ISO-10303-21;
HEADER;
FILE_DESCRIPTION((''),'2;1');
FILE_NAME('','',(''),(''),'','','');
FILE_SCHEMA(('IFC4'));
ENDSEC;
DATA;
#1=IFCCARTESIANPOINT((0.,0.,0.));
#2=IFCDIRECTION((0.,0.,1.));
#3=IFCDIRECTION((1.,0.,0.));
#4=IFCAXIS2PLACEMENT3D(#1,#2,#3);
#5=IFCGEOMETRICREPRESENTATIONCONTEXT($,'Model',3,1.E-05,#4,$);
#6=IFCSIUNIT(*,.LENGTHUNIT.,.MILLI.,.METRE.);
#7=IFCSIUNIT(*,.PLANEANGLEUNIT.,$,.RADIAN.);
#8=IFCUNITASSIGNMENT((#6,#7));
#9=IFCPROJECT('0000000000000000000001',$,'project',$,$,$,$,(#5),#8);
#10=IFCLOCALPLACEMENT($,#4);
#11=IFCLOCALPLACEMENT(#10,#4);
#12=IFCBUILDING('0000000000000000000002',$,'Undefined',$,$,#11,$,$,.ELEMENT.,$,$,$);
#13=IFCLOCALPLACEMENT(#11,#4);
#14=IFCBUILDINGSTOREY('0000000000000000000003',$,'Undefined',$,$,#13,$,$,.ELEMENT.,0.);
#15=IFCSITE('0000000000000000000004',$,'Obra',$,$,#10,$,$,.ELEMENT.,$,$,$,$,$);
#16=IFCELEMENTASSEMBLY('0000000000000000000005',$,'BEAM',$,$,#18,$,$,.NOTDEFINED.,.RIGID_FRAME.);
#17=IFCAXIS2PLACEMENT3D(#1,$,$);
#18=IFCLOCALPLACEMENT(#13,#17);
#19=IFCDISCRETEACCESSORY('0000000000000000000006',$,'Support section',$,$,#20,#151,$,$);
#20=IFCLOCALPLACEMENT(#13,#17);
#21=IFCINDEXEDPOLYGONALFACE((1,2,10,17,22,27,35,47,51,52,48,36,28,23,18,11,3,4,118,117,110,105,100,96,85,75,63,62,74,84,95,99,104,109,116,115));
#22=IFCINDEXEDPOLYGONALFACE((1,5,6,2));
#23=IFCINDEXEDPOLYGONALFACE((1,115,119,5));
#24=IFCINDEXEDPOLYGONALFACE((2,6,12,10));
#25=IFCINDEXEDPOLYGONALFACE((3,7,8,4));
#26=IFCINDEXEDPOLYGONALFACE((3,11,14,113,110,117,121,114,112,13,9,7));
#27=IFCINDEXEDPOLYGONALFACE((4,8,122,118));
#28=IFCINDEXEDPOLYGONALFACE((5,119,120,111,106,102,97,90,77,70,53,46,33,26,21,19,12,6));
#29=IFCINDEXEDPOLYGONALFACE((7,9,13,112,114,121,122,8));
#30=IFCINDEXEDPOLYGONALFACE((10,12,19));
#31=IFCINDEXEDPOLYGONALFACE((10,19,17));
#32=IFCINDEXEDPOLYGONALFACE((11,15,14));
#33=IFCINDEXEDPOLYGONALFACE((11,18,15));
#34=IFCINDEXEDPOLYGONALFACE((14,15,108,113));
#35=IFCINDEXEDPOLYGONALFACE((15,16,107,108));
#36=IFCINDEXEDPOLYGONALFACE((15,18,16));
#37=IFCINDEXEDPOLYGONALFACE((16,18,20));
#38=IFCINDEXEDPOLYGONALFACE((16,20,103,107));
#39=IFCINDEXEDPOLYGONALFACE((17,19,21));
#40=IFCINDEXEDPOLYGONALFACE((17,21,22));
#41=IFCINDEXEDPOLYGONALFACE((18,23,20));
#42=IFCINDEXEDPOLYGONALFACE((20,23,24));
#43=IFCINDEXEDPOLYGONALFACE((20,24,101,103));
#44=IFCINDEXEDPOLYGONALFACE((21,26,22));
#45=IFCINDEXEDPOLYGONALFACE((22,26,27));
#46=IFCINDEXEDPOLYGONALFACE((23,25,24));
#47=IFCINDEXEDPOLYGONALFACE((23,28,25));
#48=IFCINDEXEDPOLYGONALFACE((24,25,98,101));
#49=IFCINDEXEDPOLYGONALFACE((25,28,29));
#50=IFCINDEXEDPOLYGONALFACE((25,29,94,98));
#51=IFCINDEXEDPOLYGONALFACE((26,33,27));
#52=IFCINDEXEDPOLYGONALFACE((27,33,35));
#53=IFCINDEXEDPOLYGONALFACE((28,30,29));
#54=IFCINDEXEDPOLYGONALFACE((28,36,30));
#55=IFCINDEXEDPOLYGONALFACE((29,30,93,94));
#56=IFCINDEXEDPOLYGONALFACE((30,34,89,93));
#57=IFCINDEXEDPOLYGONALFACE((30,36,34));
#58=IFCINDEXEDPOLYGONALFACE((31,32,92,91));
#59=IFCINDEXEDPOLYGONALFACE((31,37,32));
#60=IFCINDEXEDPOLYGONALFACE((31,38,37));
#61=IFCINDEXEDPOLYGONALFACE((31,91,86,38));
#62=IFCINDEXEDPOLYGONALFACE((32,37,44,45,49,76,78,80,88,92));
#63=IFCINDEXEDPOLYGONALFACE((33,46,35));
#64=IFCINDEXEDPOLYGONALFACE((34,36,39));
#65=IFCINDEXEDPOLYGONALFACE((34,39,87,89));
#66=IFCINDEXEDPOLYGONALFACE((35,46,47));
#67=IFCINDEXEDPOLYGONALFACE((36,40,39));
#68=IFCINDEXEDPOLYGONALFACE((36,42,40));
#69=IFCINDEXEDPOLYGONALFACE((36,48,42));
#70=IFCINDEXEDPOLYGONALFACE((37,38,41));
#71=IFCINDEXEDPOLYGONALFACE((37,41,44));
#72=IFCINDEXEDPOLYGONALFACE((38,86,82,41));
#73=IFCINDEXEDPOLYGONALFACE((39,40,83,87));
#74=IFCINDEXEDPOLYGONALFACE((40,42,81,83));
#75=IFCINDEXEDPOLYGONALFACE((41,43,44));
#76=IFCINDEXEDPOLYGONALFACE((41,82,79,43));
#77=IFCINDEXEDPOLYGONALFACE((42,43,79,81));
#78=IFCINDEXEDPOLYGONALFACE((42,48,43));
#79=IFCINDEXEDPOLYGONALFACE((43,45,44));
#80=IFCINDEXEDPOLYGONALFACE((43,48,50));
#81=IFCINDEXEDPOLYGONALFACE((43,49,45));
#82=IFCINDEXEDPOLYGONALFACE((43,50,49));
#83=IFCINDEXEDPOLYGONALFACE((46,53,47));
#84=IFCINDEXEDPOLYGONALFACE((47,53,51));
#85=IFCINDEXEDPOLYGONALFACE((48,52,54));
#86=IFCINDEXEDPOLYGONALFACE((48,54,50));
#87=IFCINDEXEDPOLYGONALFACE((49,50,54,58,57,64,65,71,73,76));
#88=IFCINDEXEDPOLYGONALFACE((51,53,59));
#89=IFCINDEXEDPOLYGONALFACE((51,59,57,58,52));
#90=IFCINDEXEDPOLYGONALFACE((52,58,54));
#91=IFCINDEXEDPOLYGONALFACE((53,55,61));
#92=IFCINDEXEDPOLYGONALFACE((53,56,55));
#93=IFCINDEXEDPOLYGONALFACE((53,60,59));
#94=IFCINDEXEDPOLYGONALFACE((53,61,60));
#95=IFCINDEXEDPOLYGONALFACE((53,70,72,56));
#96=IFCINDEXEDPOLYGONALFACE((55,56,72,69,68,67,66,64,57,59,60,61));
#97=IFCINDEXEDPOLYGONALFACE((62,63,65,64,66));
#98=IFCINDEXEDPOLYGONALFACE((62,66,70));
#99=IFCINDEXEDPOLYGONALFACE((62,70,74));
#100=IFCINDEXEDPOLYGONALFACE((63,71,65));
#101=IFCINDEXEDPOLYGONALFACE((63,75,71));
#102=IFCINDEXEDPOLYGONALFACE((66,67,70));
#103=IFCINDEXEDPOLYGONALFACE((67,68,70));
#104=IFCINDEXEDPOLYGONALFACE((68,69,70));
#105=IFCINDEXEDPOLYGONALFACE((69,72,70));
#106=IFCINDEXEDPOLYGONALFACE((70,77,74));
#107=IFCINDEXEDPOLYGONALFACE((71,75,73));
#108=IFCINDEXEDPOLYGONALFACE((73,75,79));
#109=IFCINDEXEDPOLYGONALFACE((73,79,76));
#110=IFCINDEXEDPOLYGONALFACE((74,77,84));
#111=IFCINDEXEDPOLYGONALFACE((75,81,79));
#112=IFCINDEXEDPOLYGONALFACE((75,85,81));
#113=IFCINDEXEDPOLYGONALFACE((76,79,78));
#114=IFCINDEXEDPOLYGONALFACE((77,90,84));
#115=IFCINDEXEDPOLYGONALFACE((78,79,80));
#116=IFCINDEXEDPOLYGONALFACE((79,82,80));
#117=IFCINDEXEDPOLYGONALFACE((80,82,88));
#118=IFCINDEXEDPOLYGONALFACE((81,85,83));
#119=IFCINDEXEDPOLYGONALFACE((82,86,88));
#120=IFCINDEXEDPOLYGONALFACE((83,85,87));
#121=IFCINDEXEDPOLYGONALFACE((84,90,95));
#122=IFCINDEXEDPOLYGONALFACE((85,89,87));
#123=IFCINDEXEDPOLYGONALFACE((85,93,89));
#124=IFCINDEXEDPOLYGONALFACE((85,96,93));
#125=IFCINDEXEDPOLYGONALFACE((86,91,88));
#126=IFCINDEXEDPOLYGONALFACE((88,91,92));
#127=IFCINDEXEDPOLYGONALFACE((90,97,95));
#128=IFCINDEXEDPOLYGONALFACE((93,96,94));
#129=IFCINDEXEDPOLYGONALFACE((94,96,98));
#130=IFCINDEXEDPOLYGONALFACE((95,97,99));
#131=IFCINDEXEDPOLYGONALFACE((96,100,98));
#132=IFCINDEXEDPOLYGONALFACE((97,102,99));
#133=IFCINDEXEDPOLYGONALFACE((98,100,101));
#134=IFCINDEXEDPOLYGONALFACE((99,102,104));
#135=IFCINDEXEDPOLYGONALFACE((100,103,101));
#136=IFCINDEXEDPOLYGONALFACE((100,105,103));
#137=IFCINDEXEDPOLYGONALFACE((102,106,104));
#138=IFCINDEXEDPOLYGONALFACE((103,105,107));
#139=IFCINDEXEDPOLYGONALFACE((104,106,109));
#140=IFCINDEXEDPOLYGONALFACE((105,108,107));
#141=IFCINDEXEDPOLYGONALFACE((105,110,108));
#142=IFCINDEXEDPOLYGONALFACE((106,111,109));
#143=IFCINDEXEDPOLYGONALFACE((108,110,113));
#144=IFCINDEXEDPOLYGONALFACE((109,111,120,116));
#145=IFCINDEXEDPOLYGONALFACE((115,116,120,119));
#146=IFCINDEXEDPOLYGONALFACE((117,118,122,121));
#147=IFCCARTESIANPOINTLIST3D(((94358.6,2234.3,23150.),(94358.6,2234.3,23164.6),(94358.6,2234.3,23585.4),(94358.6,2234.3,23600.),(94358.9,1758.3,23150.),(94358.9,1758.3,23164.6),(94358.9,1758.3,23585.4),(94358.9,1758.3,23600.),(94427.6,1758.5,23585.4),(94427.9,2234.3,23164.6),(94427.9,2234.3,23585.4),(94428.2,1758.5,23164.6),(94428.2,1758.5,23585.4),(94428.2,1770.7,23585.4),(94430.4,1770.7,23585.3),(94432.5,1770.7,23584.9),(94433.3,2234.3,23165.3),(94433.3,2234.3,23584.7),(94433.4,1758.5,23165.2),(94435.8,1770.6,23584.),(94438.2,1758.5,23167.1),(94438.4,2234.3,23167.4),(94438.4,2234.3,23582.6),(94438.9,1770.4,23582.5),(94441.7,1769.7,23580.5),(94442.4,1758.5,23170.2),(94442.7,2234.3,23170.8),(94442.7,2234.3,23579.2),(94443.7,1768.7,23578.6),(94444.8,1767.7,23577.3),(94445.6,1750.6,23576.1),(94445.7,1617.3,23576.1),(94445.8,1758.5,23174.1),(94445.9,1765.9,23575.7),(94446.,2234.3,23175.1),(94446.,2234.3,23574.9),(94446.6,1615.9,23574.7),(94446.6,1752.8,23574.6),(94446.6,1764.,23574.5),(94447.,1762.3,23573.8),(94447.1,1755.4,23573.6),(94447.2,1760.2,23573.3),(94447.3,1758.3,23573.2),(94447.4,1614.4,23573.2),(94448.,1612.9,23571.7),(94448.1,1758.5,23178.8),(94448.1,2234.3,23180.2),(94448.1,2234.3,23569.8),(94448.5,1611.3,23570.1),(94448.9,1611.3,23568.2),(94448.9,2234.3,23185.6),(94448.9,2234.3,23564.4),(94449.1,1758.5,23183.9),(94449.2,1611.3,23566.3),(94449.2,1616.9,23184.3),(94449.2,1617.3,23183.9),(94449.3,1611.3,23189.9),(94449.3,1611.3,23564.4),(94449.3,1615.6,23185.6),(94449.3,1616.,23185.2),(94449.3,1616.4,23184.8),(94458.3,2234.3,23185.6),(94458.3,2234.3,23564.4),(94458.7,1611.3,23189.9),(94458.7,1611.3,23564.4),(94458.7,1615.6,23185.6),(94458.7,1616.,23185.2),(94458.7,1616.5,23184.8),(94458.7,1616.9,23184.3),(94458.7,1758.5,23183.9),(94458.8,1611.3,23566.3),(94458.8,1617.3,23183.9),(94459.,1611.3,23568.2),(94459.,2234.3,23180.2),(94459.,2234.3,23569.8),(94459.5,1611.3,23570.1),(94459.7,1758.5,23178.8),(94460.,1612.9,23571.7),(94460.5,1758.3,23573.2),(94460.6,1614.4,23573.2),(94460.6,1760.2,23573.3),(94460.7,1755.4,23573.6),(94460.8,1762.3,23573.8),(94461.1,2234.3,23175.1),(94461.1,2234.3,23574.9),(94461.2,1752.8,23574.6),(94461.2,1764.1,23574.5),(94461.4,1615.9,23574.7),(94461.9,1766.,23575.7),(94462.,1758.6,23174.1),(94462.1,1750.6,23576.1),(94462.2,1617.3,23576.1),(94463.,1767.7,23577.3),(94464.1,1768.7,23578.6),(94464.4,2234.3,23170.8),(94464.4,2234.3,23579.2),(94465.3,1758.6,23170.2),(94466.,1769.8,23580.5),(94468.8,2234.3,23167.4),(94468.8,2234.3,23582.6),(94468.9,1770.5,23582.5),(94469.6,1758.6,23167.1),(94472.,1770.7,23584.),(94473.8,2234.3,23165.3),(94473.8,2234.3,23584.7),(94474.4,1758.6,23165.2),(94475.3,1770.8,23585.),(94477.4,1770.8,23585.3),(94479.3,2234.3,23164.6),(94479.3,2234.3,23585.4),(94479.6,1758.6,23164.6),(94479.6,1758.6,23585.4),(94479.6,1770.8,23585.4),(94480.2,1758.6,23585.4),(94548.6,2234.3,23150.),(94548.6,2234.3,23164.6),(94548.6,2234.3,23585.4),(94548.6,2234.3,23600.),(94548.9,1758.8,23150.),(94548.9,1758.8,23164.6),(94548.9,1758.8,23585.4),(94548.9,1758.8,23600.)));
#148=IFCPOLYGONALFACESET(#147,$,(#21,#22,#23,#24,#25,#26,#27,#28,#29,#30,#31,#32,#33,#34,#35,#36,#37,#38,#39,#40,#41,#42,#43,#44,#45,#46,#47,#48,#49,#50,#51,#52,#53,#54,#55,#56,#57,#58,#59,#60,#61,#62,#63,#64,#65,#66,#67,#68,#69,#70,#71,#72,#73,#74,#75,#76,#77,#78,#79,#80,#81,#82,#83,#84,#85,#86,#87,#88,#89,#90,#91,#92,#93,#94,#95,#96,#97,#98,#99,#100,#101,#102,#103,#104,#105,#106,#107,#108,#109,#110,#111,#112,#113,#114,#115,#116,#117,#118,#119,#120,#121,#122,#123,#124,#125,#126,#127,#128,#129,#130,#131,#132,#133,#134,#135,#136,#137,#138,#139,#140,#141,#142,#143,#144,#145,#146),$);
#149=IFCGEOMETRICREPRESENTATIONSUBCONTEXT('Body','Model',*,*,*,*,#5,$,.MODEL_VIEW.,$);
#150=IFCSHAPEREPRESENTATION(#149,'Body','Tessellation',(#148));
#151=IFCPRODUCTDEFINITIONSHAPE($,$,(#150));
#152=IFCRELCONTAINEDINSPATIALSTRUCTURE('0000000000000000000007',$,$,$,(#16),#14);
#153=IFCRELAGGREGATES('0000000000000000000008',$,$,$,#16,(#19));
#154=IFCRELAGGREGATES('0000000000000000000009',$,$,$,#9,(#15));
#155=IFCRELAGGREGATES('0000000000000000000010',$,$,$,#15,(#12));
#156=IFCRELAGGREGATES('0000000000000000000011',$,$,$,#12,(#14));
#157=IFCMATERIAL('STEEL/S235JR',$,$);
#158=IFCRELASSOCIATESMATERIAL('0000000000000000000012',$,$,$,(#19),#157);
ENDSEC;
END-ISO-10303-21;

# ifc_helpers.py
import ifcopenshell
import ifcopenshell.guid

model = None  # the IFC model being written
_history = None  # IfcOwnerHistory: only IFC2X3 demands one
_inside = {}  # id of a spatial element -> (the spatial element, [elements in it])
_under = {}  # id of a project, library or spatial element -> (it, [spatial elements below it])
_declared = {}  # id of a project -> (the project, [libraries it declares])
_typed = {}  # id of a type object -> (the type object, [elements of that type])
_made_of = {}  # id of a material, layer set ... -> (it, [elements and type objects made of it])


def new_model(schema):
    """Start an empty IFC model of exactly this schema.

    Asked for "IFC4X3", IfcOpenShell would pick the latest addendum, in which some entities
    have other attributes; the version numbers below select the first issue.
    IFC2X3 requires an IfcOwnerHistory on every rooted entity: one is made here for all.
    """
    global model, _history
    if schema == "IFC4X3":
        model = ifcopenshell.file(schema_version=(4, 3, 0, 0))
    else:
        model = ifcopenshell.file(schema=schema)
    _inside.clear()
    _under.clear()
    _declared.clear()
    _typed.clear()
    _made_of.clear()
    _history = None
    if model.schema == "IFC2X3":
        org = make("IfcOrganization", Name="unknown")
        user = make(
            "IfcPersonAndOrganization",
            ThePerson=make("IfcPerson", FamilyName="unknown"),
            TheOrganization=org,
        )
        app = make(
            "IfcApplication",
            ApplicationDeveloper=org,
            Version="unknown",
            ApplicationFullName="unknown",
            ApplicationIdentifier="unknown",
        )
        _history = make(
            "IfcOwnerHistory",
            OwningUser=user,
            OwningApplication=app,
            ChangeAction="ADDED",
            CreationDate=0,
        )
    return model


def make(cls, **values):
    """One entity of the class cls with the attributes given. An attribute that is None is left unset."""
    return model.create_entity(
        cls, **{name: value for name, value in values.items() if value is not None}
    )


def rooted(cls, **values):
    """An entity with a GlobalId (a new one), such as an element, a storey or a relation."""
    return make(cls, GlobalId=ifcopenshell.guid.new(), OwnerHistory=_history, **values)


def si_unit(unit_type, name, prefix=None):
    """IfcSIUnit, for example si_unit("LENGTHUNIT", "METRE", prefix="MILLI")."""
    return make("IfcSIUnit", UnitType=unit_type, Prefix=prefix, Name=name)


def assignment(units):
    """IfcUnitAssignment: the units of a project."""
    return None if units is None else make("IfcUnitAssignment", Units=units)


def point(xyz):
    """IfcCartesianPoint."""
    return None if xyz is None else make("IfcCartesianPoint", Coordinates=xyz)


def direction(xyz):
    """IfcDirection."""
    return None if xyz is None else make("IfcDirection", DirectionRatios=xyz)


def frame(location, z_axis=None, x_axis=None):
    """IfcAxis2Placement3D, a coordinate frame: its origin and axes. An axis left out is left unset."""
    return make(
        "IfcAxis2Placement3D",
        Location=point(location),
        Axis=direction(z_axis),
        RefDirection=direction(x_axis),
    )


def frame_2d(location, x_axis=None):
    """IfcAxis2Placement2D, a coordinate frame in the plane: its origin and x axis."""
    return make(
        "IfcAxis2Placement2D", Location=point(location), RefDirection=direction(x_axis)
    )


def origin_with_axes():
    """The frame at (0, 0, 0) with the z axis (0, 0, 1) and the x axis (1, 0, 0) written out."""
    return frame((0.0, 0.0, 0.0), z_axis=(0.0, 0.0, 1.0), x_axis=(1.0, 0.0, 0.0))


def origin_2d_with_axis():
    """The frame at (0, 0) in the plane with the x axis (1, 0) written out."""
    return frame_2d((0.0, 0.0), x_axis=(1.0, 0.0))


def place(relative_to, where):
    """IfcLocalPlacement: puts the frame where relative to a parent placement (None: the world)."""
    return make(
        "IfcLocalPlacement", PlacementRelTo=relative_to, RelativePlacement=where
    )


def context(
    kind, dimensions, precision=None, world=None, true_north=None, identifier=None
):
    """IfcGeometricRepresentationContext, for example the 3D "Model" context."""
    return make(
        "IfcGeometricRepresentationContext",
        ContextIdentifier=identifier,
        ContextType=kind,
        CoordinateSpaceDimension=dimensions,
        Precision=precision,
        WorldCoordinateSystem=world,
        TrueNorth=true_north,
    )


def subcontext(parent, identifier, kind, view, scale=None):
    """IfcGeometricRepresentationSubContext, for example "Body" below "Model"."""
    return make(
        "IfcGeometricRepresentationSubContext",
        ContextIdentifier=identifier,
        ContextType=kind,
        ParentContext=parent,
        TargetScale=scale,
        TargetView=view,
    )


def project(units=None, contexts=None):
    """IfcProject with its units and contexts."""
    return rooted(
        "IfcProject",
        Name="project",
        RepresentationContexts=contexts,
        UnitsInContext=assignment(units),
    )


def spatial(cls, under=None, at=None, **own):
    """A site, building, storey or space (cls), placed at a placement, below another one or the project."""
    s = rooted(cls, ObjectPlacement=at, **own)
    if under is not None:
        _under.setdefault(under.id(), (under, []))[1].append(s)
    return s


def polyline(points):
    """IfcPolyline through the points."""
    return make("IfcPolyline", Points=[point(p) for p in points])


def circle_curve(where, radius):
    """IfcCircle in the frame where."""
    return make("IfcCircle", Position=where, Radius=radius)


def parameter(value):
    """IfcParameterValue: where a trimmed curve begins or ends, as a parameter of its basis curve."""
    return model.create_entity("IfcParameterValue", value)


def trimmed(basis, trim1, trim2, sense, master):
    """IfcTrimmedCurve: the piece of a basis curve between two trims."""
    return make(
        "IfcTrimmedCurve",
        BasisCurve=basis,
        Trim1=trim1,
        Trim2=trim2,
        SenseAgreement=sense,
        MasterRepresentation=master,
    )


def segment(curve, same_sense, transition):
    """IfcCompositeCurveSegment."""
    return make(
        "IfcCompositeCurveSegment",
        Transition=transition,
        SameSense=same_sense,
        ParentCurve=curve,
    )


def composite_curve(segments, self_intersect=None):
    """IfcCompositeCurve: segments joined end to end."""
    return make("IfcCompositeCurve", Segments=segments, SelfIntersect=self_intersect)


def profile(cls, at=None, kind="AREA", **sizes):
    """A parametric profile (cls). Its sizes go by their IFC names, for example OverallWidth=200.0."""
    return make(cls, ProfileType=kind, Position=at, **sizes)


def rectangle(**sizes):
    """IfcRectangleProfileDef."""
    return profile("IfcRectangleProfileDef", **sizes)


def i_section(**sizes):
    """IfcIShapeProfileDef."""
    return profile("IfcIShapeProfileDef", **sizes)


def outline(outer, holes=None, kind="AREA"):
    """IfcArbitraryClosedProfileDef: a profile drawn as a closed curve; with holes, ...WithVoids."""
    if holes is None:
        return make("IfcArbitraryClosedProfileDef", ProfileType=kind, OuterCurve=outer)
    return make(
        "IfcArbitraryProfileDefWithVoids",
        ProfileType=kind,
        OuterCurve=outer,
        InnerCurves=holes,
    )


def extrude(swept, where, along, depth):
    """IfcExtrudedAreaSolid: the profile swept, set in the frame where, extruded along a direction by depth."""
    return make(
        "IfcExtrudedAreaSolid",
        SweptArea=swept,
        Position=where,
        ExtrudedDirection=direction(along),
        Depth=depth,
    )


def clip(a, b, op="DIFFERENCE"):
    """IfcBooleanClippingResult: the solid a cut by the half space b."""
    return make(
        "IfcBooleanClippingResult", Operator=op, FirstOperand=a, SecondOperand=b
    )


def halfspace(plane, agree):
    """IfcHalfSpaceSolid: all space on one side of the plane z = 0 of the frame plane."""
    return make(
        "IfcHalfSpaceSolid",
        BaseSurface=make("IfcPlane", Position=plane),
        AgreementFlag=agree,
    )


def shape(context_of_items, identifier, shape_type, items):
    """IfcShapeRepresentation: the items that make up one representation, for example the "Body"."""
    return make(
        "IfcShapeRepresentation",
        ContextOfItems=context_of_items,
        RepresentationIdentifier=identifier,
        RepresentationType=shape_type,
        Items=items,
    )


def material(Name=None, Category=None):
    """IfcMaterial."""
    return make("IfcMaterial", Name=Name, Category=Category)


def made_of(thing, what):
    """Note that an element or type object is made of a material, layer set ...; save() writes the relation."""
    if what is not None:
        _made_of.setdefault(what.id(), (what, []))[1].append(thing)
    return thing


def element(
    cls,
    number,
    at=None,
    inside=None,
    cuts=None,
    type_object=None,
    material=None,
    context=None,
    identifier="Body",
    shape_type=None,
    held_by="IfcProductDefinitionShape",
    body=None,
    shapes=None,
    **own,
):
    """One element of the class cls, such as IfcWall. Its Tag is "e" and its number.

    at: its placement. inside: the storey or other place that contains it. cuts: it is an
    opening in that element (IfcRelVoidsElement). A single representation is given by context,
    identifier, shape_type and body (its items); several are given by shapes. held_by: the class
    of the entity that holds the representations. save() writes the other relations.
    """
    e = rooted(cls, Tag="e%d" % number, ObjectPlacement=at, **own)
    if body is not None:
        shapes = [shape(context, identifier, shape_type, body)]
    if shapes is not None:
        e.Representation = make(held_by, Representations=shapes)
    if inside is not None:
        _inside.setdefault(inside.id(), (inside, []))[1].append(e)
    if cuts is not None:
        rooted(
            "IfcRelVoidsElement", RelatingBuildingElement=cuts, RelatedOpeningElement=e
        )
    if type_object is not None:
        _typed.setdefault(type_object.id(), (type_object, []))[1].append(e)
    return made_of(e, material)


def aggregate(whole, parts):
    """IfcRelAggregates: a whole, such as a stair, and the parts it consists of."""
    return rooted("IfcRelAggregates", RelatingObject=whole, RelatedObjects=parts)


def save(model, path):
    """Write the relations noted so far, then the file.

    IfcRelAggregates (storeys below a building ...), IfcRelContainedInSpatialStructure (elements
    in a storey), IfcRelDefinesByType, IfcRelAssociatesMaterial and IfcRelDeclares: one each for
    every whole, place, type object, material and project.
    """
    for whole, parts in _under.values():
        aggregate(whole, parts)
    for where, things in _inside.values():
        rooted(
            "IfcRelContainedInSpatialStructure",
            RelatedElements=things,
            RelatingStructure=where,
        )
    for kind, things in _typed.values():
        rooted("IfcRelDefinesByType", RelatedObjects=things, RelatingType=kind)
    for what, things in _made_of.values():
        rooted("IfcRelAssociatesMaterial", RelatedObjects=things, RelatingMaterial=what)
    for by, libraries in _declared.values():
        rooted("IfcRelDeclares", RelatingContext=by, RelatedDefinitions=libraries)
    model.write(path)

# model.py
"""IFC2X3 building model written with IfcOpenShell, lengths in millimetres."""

from ifc_helpers import new_model, si_unit, frame, frame_2d, origin_with_axes, origin_2d_with_axis, place, context, subcontext, project, spatial, polyline, circle_curve, parameter, trimmed, segment, composite_curve, rectangle, i_section, outline, extrude, clip, halfspace, material, element, aggregate, save


model = new_model("IFC2X3")

# Units and contexts
model_context = context("Model", 3, precision=1e-05, world=origin_with_axes())
body_context = subcontext(model_context, "Body", "Model", "MODEL_VIEW")
ifc_project = project(units=[si_unit("LENGTHUNIT", "METRE", prefix="MILLI"), si_unit("PLANEANGLEUNIT", "RADIAN")], contexts=[model_context])

# Site, building, storey
site_placement = place(None, origin_with_axes())
site = spatial("IfcSite", under=ifc_project, at=site_placement, Name="Obra", CompositionType="ELEMENT")
building_placement = place(site_placement, origin_with_axes())
building = spatial("IfcBuilding", under=site, at=building_placement, Name="Undefined", CompositionType="ELEMENT")
storey_placement = place(building_placement, origin_with_axes())
storey = spatial("IfcBuildingStorey", under=building, at=storey_placement, Name="Undefined", CompositionType="ELEMENT", Elevation=0.0)

# Shared definitions
ifc_material_1 = material(Name="STEEL/S235JR")

# Element assembly, discrete accessory, openings
assembly_1_placement = place(storey_placement, origin_with_axes())
assembly_1 = element("IfcElementAssembly", 1, at=assembly_1_placement, inside=storey, Name="BEAM", AssemblyPlace="NOTDEFINED", PredefinedType="RIGID_FRAME")
discrete_accessory_1_placement = place(assembly_1_placement, frame((94454.0, 1611.3, 23375.0), z_axis=(0.0, 0.0, 1.0), x_axis=(-0.000688, 1.0, 0.0)))
discrete_accessory_1 = element("IfcDiscreteAccessory", 2, at=discrete_accessory_1_placement, material=ifc_material_1, Name="Support section", context=body_context, shape_type="Clipping", body=[
    clip(clip(extrude(i_section(OverallWidth=190.0, OverallDepth=450.0, WebThickness=9.4, FlangeThickness=14.6, FilletRadius=21.0, at=origin_2d_with_axis()), frame((623.2, 0.0, 0.0), z_axis=(-1.0, 0.0, 0.0), x_axis=(0.0, -1.0, 0.0)), (0.0, 0.0, 1.0), 623.1), halfspace(frame((622.3, -1000.0, 0.0), z_axis=(-1.0, 0.000688, 0.0), x_axis=(0.0, 0.0, -1.0)), True)), halfspace(frame((0.0, 0.0, 1000.0), z_axis=(-0.999998, -0.002038, 0.0), x_axis=(0.002038, -0.999998, 0.0)), False)),
])
opening_1_placement = place(assembly_1_placement, frame((94454.0, 1611.3, 23375.0), z_axis=(0.0, 0.0, 1.0), x_axis=(-0.000688, 1.0, 0.0)))
element("IfcOpeningElement", 3, at=opening_1_placement, cuts=discrete_accessory_1, ObjectType="Recess", context=body_context, shape_type="SweptSolid", body=[
    extrude(outline(polyline([(0.0, 0.0), (14.0, 0.0), (7.0, 7.0), (0.0, 0.0)])), frame((9.4, 26.3, -194.5), z_axis=(0.002038, -0.999998, 0.0), x_axis=(-0.707105, -0.001441, 0.707107)), (0.0, 0.0, 1.0), 52.6),
])
opening_2_placement = place(assembly_1_placement, frame((94454.0, 1611.3, 23375.0), z_axis=(0.0, 0.0, 1.0), x_axis=(-0.000688, 1.0, 0.0)))
element("IfcOpeningElement", 4, at=opening_2_placement, cuts=discrete_accessory_1, ObjectType="Recess", context=body_context, shape_type="SweptSolid", body=[
    extrude(outline(composite_curve([segment(trimmed(circle_curve(frame_2d((8.7, 8.7), x_axis=(-0.707107, -0.707107)), 12.2), [parameter(0.0)], [parameter(3.141593)], True, "PARAMETER"), True, "CONTINUOUS"), segment(polyline([(17.3, 17.3), (0.0, 0.0)]), True, "CONTINUOUS")], self_intersect=True)), frame((135.0, 26.3, 210.4), z_axis=(0.002038, -0.999998, 0.0), x_axis=(0.707105, 0.001441, -0.707107)), (0.0, 0.0, 1.0), 52.6),
])
opening_3_placement = place(assembly_1_placement, frame((94454.0, 1611.3, 23375.0), z_axis=(0.0, 0.0, 1.0), x_axis=(-0.000688, 1.0, 0.0)))
element("IfcOpeningElement", 5, at=opening_3_placement, cuts=discrete_accessory_1, ObjectType="Recess", context=body_context, shape_type="SweptSolid", body=[
    extrude(outline(polyline([(0.0, 0.0), (14.0, 0.0), (7.0, 7.0), (0.0, 0.0)])), frame((-0.6, 26.3, 194.6), z_axis=(0.002038, -0.999998, 0.0), x_axis=(0.707105, 0.001441, 0.707107)), (0.0, 0.0, 1.0), 52.6),
])
opening_4_placement = place(assembly_1_placement, frame((94454.0, 1611.3, 23375.0), z_axis=(0.0, 0.0, 1.0), x_axis=(-0.000688, 1.0, 0.0)))
element("IfcOpeningElement", 6, at=opening_4_placement, cuts=discrete_accessory_1, ObjectType="Recess", context=body_context, shape_type="SweptSolid", body=[
    extrude(rectangle(XDim=35.9, YDim=150.0, at=origin_2d_with_axis()), frame((72.5, -98.2, -209.0), z_axis=(-0.002038, 0.999998, 0.0), x_axis=(0.0, 0.0, -1.0)), (0.0, 0.0, 1.0), 195.3),
])
opening_5_placement = place(assembly_1_placement, frame((94454.0, 1611.3, 23375.0), z_axis=(0.0, 0.0, 1.0), x_axis=(-0.000688, 1.0, 0.0)))
element("IfcOpeningElement", 7, at=opening_5_placement, cuts=discrete_accessory_1, ObjectType="Recess", context=body_context, shape_type="SweptSolid", body=[
    extrude(rectangle(XDim=25.9, YDim=150.0, at=origin_2d_with_axis()), frame((72.5, -98.2, 214.0), z_axis=(-0.002038, 0.999998, 0.0), x_axis=(0.0, 0.0, -1.0)), (0.0, 0.0, 1.0), 195.3),
])
aggregate(assembly_1, [discrete_accessory_1])

save(model, "model.ifc")
